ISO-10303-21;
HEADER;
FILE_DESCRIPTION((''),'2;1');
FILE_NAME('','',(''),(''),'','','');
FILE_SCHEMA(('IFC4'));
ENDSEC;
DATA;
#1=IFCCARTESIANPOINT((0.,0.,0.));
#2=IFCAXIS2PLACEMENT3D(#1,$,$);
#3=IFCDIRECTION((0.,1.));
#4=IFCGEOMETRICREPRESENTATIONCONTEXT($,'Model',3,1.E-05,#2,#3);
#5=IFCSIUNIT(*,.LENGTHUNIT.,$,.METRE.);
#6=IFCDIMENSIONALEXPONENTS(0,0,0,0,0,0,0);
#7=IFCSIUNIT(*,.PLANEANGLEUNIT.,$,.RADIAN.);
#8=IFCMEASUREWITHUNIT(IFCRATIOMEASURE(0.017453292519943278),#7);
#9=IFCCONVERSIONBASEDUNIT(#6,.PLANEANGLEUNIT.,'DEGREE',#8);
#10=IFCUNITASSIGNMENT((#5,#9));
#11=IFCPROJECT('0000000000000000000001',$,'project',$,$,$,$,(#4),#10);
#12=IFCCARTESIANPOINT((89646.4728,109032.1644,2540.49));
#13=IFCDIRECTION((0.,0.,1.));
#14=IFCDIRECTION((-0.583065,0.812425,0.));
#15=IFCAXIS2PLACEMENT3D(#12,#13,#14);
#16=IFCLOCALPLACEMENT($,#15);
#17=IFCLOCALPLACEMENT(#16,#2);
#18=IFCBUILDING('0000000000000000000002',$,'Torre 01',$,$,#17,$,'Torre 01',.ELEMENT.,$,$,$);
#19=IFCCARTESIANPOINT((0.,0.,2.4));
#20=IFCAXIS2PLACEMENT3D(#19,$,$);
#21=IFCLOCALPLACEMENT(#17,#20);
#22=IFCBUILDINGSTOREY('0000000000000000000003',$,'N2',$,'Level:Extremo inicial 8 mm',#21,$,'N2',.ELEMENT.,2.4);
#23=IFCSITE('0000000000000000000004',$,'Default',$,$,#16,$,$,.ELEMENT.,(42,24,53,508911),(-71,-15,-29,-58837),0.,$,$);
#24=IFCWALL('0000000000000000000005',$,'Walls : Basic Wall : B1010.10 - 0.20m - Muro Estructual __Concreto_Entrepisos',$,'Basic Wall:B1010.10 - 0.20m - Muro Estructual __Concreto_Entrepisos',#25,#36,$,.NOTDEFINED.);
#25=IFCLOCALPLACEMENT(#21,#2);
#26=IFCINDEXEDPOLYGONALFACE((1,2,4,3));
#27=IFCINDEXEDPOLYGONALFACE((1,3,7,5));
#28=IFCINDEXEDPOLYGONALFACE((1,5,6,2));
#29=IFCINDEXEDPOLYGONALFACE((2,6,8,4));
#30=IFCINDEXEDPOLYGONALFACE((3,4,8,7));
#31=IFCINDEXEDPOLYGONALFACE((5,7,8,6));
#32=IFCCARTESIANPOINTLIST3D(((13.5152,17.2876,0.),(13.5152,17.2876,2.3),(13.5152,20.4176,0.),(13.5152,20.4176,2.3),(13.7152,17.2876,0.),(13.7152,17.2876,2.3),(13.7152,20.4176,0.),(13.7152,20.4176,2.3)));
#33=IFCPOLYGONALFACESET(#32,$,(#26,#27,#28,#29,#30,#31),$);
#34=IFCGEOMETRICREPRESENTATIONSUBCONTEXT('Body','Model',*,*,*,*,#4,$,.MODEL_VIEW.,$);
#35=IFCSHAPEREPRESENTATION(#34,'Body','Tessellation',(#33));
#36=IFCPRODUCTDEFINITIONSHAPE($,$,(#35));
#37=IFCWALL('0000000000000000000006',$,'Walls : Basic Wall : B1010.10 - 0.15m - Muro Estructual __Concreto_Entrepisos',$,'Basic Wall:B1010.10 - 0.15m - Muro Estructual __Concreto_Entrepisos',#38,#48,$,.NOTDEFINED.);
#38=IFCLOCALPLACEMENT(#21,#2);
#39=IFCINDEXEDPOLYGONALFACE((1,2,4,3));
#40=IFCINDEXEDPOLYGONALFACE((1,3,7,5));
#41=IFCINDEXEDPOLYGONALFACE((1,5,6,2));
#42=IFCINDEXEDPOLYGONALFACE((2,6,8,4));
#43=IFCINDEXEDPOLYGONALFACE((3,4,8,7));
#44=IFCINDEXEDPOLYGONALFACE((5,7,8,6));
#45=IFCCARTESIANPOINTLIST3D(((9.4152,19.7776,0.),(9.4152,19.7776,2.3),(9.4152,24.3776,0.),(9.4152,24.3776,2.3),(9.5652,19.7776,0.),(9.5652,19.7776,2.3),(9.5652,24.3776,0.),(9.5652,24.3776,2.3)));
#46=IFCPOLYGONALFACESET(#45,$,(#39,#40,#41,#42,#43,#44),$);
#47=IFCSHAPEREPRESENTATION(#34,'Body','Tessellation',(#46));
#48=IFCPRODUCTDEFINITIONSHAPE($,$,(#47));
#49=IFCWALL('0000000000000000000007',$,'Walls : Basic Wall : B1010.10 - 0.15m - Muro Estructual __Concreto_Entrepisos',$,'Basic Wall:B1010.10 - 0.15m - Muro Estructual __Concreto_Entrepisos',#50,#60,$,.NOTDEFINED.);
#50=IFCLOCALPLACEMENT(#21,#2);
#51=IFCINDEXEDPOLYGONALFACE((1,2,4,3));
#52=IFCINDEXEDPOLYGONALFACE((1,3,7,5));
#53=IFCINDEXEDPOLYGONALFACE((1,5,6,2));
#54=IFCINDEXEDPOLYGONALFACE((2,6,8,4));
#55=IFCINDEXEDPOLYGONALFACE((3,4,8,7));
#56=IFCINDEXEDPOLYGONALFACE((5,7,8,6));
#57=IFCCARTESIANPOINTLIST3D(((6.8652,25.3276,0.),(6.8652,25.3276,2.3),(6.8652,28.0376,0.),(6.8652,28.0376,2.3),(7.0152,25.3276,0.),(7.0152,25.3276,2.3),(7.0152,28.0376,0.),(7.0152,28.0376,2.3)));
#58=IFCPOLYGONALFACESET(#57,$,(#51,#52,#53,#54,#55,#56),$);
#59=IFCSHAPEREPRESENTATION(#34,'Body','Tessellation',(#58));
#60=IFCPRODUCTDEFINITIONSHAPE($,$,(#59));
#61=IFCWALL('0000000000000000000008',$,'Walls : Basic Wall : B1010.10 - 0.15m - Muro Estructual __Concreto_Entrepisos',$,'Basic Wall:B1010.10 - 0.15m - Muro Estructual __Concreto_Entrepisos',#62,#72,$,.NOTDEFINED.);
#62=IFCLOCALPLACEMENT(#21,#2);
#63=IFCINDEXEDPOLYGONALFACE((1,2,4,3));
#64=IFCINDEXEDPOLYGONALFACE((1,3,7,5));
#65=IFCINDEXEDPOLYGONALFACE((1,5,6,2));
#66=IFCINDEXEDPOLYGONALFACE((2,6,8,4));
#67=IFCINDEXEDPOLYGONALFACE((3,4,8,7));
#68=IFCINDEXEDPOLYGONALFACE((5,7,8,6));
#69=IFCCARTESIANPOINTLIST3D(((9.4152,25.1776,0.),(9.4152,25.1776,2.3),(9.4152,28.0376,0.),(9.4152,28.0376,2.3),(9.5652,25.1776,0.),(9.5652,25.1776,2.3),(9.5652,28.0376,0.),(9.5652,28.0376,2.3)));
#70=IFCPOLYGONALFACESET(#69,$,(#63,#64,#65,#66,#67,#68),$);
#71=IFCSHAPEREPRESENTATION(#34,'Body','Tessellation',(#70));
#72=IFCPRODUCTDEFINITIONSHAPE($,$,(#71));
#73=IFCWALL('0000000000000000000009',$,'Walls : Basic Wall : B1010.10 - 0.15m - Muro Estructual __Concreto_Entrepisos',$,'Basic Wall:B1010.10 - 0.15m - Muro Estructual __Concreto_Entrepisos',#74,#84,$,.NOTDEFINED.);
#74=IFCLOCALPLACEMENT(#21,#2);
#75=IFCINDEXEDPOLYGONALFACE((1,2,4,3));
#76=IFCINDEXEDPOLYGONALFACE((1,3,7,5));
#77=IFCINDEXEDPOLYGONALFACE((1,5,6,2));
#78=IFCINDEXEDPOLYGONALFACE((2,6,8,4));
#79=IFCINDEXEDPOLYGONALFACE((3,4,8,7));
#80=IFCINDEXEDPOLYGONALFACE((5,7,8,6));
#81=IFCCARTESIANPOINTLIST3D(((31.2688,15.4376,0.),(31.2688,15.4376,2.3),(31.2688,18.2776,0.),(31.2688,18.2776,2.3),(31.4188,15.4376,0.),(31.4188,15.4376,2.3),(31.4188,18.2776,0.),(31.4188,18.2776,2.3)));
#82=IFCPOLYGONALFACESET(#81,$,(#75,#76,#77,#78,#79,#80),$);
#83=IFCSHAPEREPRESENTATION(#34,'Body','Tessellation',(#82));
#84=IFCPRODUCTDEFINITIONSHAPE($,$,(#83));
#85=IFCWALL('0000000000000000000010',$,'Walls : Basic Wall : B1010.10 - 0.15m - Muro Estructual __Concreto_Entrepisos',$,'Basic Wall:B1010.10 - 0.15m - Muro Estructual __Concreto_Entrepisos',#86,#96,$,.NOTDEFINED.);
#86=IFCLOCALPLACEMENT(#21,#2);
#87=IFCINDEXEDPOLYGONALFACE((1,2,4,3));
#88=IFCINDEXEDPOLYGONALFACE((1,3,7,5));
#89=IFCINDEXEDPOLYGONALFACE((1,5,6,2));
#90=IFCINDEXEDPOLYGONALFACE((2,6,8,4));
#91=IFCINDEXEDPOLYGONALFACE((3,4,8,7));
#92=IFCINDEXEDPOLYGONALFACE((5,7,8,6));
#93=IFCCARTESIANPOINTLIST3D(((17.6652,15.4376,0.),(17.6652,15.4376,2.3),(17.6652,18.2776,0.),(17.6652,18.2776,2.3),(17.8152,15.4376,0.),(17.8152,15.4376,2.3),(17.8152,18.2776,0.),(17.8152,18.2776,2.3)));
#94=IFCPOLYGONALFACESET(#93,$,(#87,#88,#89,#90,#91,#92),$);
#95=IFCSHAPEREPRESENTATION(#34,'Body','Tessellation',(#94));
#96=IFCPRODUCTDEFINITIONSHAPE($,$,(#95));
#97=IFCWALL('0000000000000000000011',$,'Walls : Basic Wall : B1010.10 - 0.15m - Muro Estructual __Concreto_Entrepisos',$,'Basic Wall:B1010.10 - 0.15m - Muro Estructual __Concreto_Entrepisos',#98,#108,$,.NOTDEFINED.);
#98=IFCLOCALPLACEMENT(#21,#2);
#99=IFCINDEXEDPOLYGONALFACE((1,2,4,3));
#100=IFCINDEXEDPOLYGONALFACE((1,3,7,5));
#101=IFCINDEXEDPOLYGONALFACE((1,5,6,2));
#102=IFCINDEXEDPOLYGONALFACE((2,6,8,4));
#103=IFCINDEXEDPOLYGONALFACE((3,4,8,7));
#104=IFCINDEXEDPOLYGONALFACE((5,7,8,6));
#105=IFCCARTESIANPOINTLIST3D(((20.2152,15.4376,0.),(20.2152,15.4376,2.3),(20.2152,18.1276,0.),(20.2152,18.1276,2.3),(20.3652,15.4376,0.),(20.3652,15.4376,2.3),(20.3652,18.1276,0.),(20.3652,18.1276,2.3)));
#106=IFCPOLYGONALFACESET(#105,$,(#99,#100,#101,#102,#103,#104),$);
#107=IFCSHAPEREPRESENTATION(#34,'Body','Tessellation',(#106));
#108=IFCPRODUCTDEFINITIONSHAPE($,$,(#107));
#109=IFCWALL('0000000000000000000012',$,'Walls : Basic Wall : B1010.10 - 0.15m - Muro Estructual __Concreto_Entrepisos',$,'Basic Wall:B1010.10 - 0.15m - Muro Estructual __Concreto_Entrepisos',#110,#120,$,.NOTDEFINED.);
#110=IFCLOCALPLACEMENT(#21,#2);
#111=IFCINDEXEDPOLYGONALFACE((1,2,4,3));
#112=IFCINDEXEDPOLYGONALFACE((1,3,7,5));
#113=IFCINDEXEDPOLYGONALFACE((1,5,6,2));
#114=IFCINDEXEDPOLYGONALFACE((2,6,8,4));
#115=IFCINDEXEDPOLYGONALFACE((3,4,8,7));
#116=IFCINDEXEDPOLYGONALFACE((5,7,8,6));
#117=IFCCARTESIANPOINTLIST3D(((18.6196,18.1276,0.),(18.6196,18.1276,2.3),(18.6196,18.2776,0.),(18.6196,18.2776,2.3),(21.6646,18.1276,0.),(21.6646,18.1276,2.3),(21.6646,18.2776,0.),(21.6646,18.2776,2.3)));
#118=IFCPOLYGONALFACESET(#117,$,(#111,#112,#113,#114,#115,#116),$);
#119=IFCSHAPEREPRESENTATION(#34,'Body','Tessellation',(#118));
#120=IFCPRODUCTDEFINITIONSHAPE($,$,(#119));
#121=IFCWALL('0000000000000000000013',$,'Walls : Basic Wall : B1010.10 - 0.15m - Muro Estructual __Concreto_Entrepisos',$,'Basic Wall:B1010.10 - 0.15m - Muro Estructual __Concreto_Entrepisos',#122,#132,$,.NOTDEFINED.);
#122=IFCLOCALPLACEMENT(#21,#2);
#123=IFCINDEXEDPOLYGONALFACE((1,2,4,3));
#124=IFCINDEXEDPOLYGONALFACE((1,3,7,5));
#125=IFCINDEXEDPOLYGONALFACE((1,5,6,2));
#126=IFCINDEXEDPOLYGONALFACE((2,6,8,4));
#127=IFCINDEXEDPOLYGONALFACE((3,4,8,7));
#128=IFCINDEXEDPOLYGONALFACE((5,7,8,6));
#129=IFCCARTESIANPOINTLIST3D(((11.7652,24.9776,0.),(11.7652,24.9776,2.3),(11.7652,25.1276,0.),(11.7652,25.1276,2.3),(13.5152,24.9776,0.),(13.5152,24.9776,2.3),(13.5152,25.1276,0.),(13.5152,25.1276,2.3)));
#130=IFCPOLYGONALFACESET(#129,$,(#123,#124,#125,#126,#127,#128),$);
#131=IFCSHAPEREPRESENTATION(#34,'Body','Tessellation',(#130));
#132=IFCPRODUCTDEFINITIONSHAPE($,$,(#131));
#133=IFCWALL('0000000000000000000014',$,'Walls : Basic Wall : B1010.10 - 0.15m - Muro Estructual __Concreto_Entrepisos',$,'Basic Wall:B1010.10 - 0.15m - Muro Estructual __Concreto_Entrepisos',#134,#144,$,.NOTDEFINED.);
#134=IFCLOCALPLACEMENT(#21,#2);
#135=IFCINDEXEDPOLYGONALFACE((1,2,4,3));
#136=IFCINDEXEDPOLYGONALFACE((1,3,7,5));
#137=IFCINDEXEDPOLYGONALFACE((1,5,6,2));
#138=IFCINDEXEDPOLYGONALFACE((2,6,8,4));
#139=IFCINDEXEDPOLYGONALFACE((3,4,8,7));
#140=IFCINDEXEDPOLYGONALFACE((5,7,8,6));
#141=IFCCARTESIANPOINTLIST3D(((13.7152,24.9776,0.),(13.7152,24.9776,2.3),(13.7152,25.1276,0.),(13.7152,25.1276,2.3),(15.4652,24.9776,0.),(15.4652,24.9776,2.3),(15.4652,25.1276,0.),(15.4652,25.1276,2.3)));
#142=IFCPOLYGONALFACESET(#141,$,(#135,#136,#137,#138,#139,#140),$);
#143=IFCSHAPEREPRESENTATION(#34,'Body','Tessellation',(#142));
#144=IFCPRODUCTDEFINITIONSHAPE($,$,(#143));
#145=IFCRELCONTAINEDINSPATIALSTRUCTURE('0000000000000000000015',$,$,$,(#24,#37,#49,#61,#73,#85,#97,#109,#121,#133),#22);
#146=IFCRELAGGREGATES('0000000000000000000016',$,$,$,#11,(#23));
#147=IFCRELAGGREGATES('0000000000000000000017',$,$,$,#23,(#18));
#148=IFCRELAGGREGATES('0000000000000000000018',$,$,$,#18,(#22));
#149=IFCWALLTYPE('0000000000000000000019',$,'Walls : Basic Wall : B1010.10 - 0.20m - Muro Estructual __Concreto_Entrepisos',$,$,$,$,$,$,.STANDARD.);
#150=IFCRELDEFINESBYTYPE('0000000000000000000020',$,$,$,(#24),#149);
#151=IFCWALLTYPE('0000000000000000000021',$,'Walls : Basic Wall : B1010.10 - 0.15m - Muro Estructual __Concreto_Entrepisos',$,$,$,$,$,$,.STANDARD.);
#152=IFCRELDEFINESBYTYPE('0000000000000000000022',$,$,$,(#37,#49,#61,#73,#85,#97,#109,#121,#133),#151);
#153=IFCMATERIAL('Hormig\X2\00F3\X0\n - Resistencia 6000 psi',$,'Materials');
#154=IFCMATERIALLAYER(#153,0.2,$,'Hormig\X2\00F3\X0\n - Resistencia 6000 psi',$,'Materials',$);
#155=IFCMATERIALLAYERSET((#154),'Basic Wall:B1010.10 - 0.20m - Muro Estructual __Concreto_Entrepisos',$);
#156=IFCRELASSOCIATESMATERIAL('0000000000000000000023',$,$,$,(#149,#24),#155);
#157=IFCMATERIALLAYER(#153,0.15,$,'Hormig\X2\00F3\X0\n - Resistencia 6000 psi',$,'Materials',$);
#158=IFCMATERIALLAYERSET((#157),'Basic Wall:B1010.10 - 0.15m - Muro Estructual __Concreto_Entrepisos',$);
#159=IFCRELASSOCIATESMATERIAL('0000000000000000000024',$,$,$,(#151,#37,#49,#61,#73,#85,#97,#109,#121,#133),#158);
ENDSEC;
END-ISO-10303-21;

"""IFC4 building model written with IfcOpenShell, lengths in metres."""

from ifc_helpers import new_model, entity, si_unit, converted_unit, direction, frame, frame_2d, origin, place, context, subcontext, project, spatial, rectangle, extrude, material, layer, layer_set, layer_usage, type_object, element, save


model = new_model("IFC4")

# Units and contexts
model_context = context("Model", 3, precision=1e-05, world=origin(), true_north=direction((0.0, 1.0)))
body_context = subcontext(model_context, "Body", "Model", "MODEL_VIEW")
ifc_project = project(units=[si_unit("LENGTHUNIT", "METRE"), converted_unit("PLANEANGLEUNIT", "DEGREE", entity("IfcRatioMeasure", 0.017453292519943278), si_unit("PLANEANGLEUNIT", "RADIAN"), dimensions=[0, 0, 0, 0, 0, 0, 0])], contexts=[model_context])

# Site, building, storey
site_placement = place(None, frame((89646.4728, 109032.1644, 2540.49), z_axis=(0.0, 0.0, 1.0), x_axis=(-0.583065, 0.812425, 0.0)))
site = spatial("IfcSite", under=ifc_project, at=site_placement, Name="Default", CompositionType="ELEMENT", RefLatitude=(42, 24, 53, 508911), RefLongitude=(-71, -15, -29, -58837), RefElevation=0.0)
building_placement = place(site_placement, origin())
building = spatial("IfcBuilding", under=site, at=building_placement, Name="Torre 01", LongName="Torre 01", CompositionType="ELEMENT")
storey_placement = place(building_placement, frame((0.0, 0.0, 2.4)))
storey = spatial("IfcBuildingStorey", under=building, at=storey_placement, Name="N2", ObjectType="Level:Extremo inicial 8 mm", LongName="N2", CompositionType="ELEMENT", Elevation=2.4)

# Walls
ifc_material = material(Name="Hormigón - Resistencia 6000 psi", Category="Materials")
ifc_layer_1 = layer(ifc_material, 0.2, Name="Hormigón - Resistencia 6000 psi", Category="Materials")
ifc_layer_set_1 = layer_set([ifc_layer_1], Name="Basic Wall:B1010.10 - 0.20m - Muro Estructual __Concreto_Entrepisos")
wall_type_1 = type_object("IfcWallType", Name="Walls : Basic Wall : B1010.10 - 0.20m - Muro Estructual __Concreto_Entrepisos", PredefinedType="STANDARD", material=ifc_layer_set_1)
ifc_layer_usage_1 = layer_usage(ifc_layer_set_1, "AXIS2", "NEGATIVE", 0.1)
wall_1_placement = place(storey_placement, frame((13.6152, 20.4176, 0.0), z_axis=(0.0, 0.0, 1.0), x_axis=(0.0, -1.0, 0.0)))
element("IfcWall", 1, at=wall_1_placement, inside=storey, type_object=wall_type_1, material=ifc_layer_usage_1, Name="Walls : Basic Wall : B1010.10 - 0.20m - Muro Estructual __Concreto_Entrepisos", ObjectType="Basic Wall:B1010.10 - 0.20m - Muro Estructual __Concreto_Entrepisos", PredefinedType="NOTDEFINED", context=body_context, shape_type="SweptSolid", body=[
    extrude(rectangle(XDim=3.13, YDim=0.2, at=frame_2d((1.565, 0.0), x_axis=(-1.0, 0.0))), origin(), (0.0, 0.0, 1.0), 2.3),
])
ifc_layer_2 = layer(ifc_material, 0.15, Name="Hormigón - Resistencia 6000 psi", Category="Materials")
ifc_layer_set_2 = layer_set([ifc_layer_2], Name="Basic Wall:B1010.10 - 0.15m - Muro Estructual __Concreto_Entrepisos")
ifc_layer_usage_2 = layer_usage(ifc_layer_set_2, "AXIS2", "NEGATIVE", 0.075)
wall_type_2 = type_object("IfcWallType", Name="Walls : Basic Wall : B1010.10 - 0.15m - Muro Estructual __Concreto_Entrepisos", PredefinedType="STANDARD", material=ifc_layer_set_2)
wall_2_placement = place(storey_placement, frame((9.4902, 24.3776, 0.0), z_axis=(0.0, 0.0, 1.0), x_axis=(0.0, -1.0, 0.0)))
element("IfcWall", 2, at=wall_2_placement, inside=storey, type_object=wall_type_2, material=ifc_layer_usage_2, Name="Walls : Basic Wall : B1010.10 - 0.15m - Muro Estructual __Concreto_Entrepisos", ObjectType="Basic Wall:B1010.10 - 0.15m - Muro Estructual __Concreto_Entrepisos", PredefinedType="NOTDEFINED", context=body_context, shape_type="SweptSolid", body=[
    extrude(rectangle(XDim=4.6, YDim=0.15, at=frame_2d((2.3, 0.0), x_axis=(-1.0, 0.0))), origin(), (0.0, 0.0, 1.0), 2.3),
])
ifc_layer_usage_3 = layer_usage(ifc_layer_set_2, "AXIS2", "NEGATIVE", 0.075)
wall_3_placement = place(storey_placement, frame((6.9402, 25.3276, 0.0), z_axis=(0.0, 0.0, 1.0), x_axis=(0.0, 1.0, 0.0)))
element("IfcWall", 3, at=wall_3_placement, inside=storey, type_object=wall_type_2, material=ifc_layer_usage_3, Name="Walls : Basic Wall : B1010.10 - 0.15m - Muro Estructual __Concreto_Entrepisos", ObjectType="Basic Wall:B1010.10 - 0.15m - Muro Estructual __Concreto_Entrepisos", PredefinedType="NOTDEFINED", context=body_context, shape_type="SweptSolid", body=[
    extrude(rectangle(XDim=2.71, YDim=0.15, at=frame_2d((1.355, 0.0), x_axis=(-1.0, 0.0))), origin(), (0.0, 0.0, 1.0), 2.3),
])
ifc_layer_usage_4 = layer_usage(ifc_layer_set_2, "AXIS2", "NEGATIVE", 0.075)
wall_4_placement = place(storey_placement, frame((9.4902, 28.0376, 0.0), z_axis=(0.0, 0.0, 1.0), x_axis=(0.0, -1.0, 0.0)))
element("IfcWall", 4, at=wall_4_placement, inside=storey, type_object=wall_type_2, material=ifc_layer_usage_4, Name="Walls : Basic Wall : B1010.10 - 0.15m - Muro Estructual __Concreto_Entrepisos", ObjectType="Basic Wall:B1010.10 - 0.15m - Muro Estructual __Concreto_Entrepisos", PredefinedType="NOTDEFINED", context=body_context, shape_type="SweptSolid", body=[
    extrude(rectangle(XDim=2.86, YDim=0.15, at=frame_2d((1.43, 0.0), x_axis=(-1.0, 0.0))), origin(), (0.0, 0.0, 1.0), 2.3),
])
ifc_layer_usage_5 = layer_usage(ifc_layer_set_2, "AXIS2", "NEGATIVE", 0.075)
wall_5_placement = place(storey_placement, frame((31.3438, 15.4376, 0.0), z_axis=(0.0, 0.0, 1.0), x_axis=(0.0, 1.0, 0.0)))
element("IfcWall", 5, at=wall_5_placement, inside=storey, type_object=wall_type_2, material=ifc_layer_usage_5, Name="Walls : Basic Wall : B1010.10 - 0.15m - Muro Estructual __Concreto_Entrepisos", ObjectType="Basic Wall:B1010.10 - 0.15m - Muro Estructual __Concreto_Entrepisos", PredefinedType="NOTDEFINED", context=body_context, shape_type="SweptSolid", body=[
    extrude(rectangle(XDim=2.84, YDim=0.15, at=frame_2d((1.42, 0.0), x_axis=(-1.0, 0.0))), origin(), (0.0, 0.0, 1.0), 2.3),
])
ifc_layer_usage_6 = layer_usage(ifc_layer_set_2, "AXIS2", "NEGATIVE", 0.075)
wall_6_placement = place(storey_placement, frame((17.7402, 18.2776, 0.0), z_axis=(0.0, 0.0, 1.0), x_axis=(0.0, -1.0, 0.0)))
element("IfcWall", 6, at=wall_6_placement, inside=storey, type_object=wall_type_2, material=ifc_layer_usage_6, Name="Walls : Basic Wall : B1010.10 - 0.15m - Muro Estructual __Concreto_Entrepisos", ObjectType="Basic Wall:B1010.10 - 0.15m - Muro Estructual __Concreto_Entrepisos", PredefinedType="NOTDEFINED", context=body_context, shape_type="SweptSolid", body=[
    extrude(rectangle(XDim=2.84, YDim=0.15, at=frame_2d((1.42, 0.0), x_axis=(-1.0, 0.0))), origin(), (0.0, 0.0, 1.0), 2.3),
])
ifc_layer_usage_7 = layer_usage(ifc_layer_set_2, "AXIS2", "NEGATIVE", 0.075)
wall_7_placement = place(storey_placement, frame((20.2902, 15.4376, 0.0), z_axis=(0.0, 0.0, 1.0), x_axis=(0.0, 1.0, 0.0)))
element("IfcWall", 7, at=wall_7_placement, inside=storey, type_object=wall_type_2, material=ifc_layer_usage_7, Name="Walls : Basic Wall : B1010.10 - 0.15m - Muro Estructual __Concreto_Entrepisos", ObjectType="Basic Wall:B1010.10 - 0.15m - Muro Estructual __Concreto_Entrepisos", PredefinedType="NOTDEFINED", context=body_context, shape_type="SweptSolid", body=[
    extrude(rectangle(XDim=2.69, YDim=0.15, at=frame_2d((1.345, 0.0), x_axis=(-1.0, 0.0))), origin(), (0.0, 0.0, 1.0), 2.3),
])
ifc_layer_usage_8 = layer_usage(ifc_layer_set_2, "AXIS2", "NEGATIVE", 0.075)
wall_8_placement = place(storey_placement, frame((18.6196, 18.2026, 0.0)))
element("IfcWall", 8, at=wall_8_placement, inside=storey, type_object=wall_type_2, material=ifc_layer_usage_8, Name="Walls : Basic Wall : B1010.10 - 0.15m - Muro Estructual __Concreto_Entrepisos", ObjectType="Basic Wall:B1010.10 - 0.15m - Muro Estructual __Concreto_Entrepisos", PredefinedType="NOTDEFINED", context=body_context, shape_type="SweptSolid", body=[
    extrude(rectangle(XDim=3.045, YDim=0.15, at=frame_2d((1.5225, 0.0), x_axis=(-1.0, 0.0))), origin(), (0.0, 0.0, 1.0), 2.3),
])
ifc_layer_usage_9 = layer_usage(ifc_layer_set_2, "AXIS2", "POSITIVE", -0.075)
wall_9_placement = place(storey_placement, frame((11.7652, 25.0526, 0.0)))
element("IfcWall", 9, at=wall_9_placement, inside=storey, type_object=wall_type_2, material=ifc_layer_usage_9, Name="Walls : Basic Wall : B1010.10 - 0.15m - Muro Estructual __Concreto_Entrepisos", ObjectType="Basic Wall:B1010.10 - 0.15m - Muro Estructual __Concreto_Entrepisos", PredefinedType="NOTDEFINED", context=body_context, shape_type="SweptSolid", body=[
    extrude(rectangle(XDim=1.75, YDim=0.15, at=frame_2d((0.875, 0.0), x_axis=(-1.0, 0.0))), origin(), (0.0, 0.0, 1.0), 2.3),
])
ifc_layer_usage_10 = layer_usage(ifc_layer_set_2, "AXIS2", "POSITIVE", -0.075)
wall_10_placement = place(storey_placement, frame((13.7152, 25.0526, 0.0)))
element("IfcWall", 10, at=wall_10_placement, inside=storey, type_object=wall_type_2, material=ifc_layer_usage_10, Name="Walls : Basic Wall : B1010.10 - 0.15m - Muro Estructual __Concreto_Entrepisos", ObjectType="Basic Wall:B1010.10 - 0.15m - Muro Estructual __Concreto_Entrepisos", PredefinedType="NOTDEFINED", context=body_context, shape_type="SweptSolid", body=[
    extrude(rectangle(XDim=1.75, YDim=0.15, at=frame_2d((0.875, 0.0), x_axis=(-1.0, 0.0))), origin(), (0.0, 0.0, 1.0), 2.3),
])

save(model, "model.ifc")
